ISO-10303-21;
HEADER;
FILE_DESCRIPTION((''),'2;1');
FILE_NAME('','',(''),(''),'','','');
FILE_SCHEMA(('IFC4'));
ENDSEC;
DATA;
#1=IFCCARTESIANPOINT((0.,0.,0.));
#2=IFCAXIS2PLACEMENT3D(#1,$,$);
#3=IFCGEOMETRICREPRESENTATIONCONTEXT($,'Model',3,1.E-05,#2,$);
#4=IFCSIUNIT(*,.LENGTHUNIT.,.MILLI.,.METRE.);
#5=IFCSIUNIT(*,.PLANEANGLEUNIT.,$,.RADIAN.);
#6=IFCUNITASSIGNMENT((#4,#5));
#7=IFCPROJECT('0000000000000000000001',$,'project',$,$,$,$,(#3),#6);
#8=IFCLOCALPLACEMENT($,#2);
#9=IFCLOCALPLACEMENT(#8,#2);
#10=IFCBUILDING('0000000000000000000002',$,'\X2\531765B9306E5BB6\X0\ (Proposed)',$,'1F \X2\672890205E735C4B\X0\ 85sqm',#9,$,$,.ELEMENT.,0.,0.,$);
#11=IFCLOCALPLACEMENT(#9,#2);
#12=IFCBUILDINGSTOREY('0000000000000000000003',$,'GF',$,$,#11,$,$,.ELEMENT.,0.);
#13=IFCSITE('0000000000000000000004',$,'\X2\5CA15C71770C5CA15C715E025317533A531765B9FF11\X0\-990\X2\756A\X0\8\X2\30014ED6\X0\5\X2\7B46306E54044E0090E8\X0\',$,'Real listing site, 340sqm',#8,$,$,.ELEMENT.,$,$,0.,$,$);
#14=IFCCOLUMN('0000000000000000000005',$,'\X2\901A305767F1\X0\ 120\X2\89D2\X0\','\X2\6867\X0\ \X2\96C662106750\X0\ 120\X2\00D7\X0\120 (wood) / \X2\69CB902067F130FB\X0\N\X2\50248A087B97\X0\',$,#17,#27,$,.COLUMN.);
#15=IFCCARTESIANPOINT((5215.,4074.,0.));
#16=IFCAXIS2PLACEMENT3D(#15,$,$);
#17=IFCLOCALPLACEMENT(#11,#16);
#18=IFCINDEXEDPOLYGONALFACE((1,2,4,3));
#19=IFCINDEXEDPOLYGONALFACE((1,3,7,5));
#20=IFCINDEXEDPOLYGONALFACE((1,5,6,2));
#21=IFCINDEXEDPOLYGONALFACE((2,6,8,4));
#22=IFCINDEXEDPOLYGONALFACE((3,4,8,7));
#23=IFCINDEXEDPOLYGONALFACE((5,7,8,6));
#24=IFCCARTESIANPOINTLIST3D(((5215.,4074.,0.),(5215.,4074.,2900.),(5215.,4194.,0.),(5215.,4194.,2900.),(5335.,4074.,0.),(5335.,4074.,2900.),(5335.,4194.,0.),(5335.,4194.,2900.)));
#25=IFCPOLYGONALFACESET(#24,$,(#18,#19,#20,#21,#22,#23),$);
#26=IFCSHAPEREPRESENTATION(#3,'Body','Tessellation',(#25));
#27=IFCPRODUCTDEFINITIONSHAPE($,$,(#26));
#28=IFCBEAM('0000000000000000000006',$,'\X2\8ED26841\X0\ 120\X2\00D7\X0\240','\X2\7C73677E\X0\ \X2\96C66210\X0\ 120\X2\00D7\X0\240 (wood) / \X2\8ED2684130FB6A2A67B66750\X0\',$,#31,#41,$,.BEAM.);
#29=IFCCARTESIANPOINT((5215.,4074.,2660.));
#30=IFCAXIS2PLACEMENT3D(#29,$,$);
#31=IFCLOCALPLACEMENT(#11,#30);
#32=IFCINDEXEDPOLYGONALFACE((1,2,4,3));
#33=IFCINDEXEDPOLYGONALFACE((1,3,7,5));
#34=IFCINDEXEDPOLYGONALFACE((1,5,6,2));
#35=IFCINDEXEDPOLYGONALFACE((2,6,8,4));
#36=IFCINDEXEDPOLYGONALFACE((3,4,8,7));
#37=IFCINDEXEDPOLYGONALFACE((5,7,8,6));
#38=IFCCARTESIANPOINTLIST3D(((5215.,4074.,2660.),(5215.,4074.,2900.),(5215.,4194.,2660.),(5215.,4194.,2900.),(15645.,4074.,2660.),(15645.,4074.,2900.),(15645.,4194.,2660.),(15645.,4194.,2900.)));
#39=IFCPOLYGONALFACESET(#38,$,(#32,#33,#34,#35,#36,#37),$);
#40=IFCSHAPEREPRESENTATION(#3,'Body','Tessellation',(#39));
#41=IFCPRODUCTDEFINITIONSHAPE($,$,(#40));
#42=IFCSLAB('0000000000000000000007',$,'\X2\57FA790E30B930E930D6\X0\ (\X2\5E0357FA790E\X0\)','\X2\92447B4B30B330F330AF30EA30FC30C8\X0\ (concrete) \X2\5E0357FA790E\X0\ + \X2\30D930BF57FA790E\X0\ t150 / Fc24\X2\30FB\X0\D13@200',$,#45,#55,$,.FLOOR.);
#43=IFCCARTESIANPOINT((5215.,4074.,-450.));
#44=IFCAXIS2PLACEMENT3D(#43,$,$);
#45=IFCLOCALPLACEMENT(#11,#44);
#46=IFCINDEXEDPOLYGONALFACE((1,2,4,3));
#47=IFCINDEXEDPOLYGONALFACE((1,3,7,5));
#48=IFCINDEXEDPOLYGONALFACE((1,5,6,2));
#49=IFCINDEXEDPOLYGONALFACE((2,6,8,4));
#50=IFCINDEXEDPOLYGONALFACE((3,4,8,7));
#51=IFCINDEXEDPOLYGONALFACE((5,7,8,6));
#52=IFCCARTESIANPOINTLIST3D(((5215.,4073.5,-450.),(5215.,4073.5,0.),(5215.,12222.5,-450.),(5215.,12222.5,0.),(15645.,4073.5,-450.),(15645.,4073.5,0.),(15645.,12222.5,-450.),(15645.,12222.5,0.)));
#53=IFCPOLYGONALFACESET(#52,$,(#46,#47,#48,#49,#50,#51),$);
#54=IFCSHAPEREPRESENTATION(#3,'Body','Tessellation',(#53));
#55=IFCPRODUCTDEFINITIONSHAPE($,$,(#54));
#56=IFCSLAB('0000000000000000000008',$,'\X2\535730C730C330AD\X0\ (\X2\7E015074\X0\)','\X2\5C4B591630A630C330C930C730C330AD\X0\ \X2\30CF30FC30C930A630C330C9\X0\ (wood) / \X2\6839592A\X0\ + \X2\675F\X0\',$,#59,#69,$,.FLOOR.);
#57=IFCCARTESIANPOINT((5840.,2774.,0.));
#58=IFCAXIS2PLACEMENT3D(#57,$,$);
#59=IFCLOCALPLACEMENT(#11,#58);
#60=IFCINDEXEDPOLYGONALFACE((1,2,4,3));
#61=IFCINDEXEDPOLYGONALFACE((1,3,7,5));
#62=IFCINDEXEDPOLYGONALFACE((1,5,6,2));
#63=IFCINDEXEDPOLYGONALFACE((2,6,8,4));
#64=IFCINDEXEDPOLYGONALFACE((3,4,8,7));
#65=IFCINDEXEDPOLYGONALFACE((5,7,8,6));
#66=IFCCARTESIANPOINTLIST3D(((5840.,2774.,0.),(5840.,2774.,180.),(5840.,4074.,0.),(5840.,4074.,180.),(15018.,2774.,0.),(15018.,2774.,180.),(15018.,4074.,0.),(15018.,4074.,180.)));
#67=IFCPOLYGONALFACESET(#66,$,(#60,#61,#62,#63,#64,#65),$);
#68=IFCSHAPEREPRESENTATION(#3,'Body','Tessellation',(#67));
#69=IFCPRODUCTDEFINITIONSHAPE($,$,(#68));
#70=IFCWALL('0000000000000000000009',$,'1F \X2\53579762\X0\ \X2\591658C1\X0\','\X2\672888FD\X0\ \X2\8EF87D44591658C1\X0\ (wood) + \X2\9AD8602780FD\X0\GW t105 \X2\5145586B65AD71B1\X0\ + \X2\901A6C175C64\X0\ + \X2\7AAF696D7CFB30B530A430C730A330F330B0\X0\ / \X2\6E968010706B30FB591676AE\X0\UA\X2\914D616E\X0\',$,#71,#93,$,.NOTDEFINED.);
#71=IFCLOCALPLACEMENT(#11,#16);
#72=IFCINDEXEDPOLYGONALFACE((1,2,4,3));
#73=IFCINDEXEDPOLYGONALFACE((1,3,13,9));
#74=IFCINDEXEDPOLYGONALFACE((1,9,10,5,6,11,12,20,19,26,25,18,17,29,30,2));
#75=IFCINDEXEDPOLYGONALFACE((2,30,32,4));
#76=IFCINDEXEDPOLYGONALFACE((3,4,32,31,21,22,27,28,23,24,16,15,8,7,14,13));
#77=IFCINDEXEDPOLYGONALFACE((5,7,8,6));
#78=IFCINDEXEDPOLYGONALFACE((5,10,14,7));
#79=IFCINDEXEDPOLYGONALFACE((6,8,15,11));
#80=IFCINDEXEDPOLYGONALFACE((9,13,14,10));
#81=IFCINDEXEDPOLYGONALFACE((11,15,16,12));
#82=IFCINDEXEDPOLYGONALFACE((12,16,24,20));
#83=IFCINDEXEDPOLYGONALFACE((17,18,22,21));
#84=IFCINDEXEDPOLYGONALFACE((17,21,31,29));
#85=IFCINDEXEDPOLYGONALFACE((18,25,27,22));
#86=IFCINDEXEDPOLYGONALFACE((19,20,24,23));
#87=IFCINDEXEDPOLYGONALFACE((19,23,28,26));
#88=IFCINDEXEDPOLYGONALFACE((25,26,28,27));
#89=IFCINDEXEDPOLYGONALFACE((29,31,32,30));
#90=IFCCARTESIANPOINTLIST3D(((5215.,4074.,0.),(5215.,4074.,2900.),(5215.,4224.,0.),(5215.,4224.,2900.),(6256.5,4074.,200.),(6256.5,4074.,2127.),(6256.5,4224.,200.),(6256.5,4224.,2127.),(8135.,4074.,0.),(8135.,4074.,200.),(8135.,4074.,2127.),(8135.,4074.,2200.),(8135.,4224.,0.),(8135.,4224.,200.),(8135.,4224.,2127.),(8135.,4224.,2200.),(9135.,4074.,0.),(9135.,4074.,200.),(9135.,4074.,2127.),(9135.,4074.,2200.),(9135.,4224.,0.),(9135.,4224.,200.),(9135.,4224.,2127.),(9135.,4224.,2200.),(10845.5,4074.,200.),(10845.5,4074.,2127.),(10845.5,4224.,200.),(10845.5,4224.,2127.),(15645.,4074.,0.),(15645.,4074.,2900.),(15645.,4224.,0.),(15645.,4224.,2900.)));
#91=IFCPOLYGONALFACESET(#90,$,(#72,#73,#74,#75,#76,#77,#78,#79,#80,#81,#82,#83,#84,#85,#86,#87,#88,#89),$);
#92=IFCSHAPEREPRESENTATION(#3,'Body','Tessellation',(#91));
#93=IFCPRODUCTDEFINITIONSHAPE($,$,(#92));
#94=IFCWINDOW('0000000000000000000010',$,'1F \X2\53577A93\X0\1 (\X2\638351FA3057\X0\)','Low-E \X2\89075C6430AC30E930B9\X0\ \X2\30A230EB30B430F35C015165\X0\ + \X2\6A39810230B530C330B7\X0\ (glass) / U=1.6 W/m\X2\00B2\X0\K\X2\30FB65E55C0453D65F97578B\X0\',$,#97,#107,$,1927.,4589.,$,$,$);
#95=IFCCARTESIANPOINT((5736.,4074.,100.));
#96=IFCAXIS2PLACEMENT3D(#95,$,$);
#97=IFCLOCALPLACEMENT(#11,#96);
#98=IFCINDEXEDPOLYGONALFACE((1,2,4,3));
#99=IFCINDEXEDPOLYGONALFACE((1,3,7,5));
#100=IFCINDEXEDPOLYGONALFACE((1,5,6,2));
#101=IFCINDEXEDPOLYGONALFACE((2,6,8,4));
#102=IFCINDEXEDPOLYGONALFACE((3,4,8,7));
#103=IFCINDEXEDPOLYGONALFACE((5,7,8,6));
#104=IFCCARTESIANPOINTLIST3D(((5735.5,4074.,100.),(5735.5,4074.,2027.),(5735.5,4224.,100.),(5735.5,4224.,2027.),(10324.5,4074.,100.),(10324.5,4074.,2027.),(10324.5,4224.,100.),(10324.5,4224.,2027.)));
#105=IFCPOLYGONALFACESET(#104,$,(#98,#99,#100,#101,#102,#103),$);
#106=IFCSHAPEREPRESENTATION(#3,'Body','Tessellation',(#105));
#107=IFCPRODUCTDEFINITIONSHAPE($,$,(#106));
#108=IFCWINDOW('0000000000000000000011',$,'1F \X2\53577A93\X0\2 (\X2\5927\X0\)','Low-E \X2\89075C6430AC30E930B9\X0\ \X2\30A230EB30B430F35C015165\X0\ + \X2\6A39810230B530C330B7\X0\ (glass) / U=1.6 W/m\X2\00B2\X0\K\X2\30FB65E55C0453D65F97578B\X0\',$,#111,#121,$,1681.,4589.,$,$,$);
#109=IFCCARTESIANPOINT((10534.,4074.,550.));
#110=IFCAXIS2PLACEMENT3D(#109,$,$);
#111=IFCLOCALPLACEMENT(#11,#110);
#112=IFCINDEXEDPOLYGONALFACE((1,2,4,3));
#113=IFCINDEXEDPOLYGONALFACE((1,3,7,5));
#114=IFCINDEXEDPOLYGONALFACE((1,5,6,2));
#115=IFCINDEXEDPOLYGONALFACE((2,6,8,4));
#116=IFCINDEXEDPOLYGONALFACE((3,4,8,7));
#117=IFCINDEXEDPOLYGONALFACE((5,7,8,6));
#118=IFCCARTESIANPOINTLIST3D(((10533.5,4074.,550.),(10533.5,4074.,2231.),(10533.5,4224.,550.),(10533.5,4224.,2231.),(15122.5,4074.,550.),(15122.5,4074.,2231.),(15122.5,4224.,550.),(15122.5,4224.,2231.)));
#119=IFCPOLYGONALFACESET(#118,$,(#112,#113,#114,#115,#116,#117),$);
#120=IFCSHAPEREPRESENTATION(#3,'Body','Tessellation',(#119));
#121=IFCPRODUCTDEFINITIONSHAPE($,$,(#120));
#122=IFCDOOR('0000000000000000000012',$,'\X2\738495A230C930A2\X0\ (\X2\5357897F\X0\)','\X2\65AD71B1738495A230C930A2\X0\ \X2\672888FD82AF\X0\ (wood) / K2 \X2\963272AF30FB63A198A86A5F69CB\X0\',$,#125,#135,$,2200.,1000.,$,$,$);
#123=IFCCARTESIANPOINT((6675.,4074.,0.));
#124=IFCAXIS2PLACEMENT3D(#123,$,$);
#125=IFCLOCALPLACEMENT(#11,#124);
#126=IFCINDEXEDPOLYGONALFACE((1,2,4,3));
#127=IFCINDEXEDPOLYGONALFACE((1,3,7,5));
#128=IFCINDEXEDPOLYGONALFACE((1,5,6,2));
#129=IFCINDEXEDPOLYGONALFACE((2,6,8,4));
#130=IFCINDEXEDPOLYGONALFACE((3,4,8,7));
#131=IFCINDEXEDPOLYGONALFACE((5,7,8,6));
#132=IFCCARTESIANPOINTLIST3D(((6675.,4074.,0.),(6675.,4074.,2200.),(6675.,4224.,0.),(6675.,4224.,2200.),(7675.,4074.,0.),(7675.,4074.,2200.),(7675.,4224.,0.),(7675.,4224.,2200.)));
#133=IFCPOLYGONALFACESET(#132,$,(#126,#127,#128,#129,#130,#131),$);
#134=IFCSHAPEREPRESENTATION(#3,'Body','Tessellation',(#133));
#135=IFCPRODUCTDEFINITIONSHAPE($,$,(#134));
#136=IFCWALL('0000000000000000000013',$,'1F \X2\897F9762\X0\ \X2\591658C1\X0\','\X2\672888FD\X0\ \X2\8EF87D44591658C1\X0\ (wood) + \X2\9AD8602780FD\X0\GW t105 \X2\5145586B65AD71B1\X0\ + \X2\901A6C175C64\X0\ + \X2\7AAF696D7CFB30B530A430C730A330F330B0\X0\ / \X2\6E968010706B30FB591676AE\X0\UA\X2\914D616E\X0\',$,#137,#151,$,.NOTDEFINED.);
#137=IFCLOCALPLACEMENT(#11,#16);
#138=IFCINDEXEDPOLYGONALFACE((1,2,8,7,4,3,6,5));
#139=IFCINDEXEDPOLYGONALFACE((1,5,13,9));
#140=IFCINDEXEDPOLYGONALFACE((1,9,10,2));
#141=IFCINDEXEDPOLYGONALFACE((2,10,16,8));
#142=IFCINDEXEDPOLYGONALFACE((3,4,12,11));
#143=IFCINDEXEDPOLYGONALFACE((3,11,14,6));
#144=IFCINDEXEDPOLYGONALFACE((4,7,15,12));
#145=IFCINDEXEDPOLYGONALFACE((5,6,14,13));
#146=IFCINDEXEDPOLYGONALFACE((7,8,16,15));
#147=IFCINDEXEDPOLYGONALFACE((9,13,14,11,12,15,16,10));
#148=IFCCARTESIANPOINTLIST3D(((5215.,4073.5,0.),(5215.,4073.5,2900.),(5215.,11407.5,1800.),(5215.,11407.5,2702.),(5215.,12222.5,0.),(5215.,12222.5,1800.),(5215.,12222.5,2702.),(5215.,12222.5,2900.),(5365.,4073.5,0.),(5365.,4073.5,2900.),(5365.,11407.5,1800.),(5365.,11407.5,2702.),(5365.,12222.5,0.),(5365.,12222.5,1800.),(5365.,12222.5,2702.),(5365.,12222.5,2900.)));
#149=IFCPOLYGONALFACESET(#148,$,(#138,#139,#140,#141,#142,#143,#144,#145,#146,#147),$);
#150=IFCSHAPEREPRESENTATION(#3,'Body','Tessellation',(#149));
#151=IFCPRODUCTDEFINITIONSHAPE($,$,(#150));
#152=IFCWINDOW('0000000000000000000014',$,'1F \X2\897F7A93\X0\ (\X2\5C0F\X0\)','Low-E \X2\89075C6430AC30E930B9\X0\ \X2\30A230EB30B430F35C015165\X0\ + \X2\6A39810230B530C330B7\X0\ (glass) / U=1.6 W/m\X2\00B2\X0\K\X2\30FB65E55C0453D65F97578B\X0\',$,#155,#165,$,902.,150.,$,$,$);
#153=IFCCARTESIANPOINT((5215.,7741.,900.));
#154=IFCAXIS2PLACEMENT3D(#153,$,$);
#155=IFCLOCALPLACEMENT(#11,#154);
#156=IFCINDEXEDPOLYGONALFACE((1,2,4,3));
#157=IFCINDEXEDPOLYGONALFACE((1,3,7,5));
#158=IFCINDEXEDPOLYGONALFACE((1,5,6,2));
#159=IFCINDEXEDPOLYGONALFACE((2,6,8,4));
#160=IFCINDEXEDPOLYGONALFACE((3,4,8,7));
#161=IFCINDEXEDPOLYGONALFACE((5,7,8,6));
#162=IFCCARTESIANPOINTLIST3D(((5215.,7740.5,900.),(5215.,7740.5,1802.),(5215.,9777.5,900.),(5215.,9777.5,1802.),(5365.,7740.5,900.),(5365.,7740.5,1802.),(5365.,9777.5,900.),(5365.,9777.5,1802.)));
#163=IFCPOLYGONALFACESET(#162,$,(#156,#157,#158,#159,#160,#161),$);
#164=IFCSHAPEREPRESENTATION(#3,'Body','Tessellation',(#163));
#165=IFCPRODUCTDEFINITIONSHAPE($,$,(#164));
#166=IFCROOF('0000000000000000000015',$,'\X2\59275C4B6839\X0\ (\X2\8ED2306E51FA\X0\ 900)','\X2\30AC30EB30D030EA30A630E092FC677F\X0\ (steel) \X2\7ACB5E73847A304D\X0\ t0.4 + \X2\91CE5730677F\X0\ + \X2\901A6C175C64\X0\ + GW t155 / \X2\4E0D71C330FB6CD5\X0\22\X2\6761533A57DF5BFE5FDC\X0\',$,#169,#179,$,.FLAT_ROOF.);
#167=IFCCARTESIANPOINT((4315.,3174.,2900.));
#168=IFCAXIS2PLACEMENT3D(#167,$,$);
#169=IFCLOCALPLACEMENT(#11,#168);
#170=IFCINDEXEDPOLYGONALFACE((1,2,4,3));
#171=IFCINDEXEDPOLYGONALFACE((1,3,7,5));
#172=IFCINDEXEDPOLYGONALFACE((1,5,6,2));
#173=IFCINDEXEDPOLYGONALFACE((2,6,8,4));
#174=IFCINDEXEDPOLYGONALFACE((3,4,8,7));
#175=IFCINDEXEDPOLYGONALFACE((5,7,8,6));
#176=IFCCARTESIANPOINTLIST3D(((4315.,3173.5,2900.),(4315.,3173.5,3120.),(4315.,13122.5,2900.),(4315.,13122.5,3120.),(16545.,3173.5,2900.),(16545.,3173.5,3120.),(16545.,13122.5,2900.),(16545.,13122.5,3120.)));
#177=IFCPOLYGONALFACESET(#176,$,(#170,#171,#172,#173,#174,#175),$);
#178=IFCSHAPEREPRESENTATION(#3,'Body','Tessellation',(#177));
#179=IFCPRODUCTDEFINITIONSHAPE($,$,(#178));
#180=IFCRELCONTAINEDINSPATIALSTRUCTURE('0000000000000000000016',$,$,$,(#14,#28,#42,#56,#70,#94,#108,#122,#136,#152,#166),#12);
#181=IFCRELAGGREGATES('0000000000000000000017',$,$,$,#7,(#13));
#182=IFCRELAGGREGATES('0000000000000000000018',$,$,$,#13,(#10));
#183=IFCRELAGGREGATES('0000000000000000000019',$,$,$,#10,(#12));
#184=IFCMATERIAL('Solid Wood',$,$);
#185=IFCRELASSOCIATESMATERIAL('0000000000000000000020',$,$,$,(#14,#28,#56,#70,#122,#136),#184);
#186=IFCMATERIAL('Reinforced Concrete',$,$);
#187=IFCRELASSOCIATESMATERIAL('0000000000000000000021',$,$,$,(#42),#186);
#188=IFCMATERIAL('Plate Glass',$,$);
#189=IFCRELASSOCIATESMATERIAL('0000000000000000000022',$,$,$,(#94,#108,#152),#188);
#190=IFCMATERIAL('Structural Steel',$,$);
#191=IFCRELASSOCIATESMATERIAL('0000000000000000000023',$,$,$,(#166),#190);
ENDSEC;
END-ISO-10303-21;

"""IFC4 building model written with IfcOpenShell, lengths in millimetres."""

from ifc_helpers import new_model, si_unit, frame, frame_2d, origin, place, context, project, spatial, rectangle, extrude, material, element, fill, save


model = new_model("IFC4")

# Units and contexts
model_context = context("Model", 3, precision=1e-05, world=origin())
ifc_project = project(units=[si_unit("LENGTHUNIT", "METRE", prefix="MILLI"), si_unit("PLANEANGLEUNIT", "RADIAN")], contexts=[model_context])

# Site, building, storey
site_placement = place(None, origin())
site = spatial("IfcSite", under=ifc_project, at=site_placement, Name="岡山県岡山市北区北方１-990番8、他5筆の各一部", ObjectType="Real listing site, 340sqm", CompositionType="ELEMENT", RefElevation=0.0)
building_placement = place(site_placement, origin())
building = spatial("IfcBuilding", under=site, at=building_placement, Name="北方の家 (Proposed)", ObjectType="1F 木造平屋 85sqm", CompositionType="ELEMENT", ElevationOfRefHeight=0.0, ElevationOfTerrain=0.0)
storey_placement = place(building_placement, origin())
storey = spatial("IfcBuildingStorey", under=building, at=storey_placement, Name="GF", CompositionType="ELEMENT", Elevation=0.0)

# Column
ifc_material_1 = material(Name="Solid Wood")
column_1_placement = place(storey_placement, frame((5215.0, 4074.0, 0.0)))
element("IfcColumn", 1, at=column_1_placement, inside=storey, material=ifc_material_1, Name="通し柱 120角", Description="桧 集成材 120×120 (wood) / 構造柱・N値計算", PredefinedType="COLUMN", context=model_context, shape_type="SweptSolid", body=[
    extrude(rectangle(XDim=120.0, YDim=120.0, at=frame_2d((60.0, 60.0))), frame((5215.0, 4074.0, 0.0)), (0.0, 0.0, 1.0), 2900.0),
])

# Beam
beam_1_placement = place(storey_placement, frame((5215.0, 4074.0, 2660.0)))
element("IfcBeam", 2, at=beam_1_placement, inside=storey, material=ifc_material_1, Name="軒桁 120×240", Description="米松 集成 120×240 (wood) / 軒桁・横架材", PredefinedType="BEAM", context=model_context, shape_type="SweptSolid", body=[
    extrude(rectangle(XDim=10430.0, YDim=120.0, at=frame_2d((5215.0, 60.0))), frame((5215.0, 4074.0, 2660.0)), (0.0, 0.0, 1.0), 240.0),
])

# Slabs
ifc_material_2 = material(Name="Reinforced Concrete")
slab_1_placement = place(storey_placement, frame((5215.0, 4074.0, -450.0)))
element("IfcSlab", 3, at=slab_1_placement, inside=storey, material=ifc_material_2, Name="基礎スラブ (布基礎)", Description="鉄筋コンクリート (concrete) 布基礎 + ベタ基礎 t150 / Fc24・D13@200", PredefinedType="FLOOR", context=model_context, shape_type="SweptSolid", body=[
    extrude(rectangle(XDim=10430.0, YDim=8149.0, at=frame_2d((5215.0, 4074.0))), frame((5215.0, 4074.0, -450.0)), (0.0, 0.0, 1.0), 450.0),
])
slab_2_placement = place(storey_placement, frame((5840.0, 2774.0, 0.0)))
element("IfcSlab", 4, at=slab_2_placement, inside=storey, material=ifc_material_1, Name="南デッキ (縁側)", Description="屋外ウッドデッキ ハードウッド (wood) / 根太 + 束", PredefinedType="FLOOR", context=model_context, shape_type="SweptSolid", body=[
    extrude(rectangle(XDim=9178.0, YDim=1300.0, at=frame_2d((4589.0, 650.0))), frame((5840.0, 2774.0, 0.0)), (0.0, 0.0, 1.0), 180.0),
])

# Wall, openings, windows, door
wall_1_placement = place(storey_placement, frame((5215.0, 4074.0, 0.0)))
wall_1 = element("IfcWall", 5, at=wall_1_placement, inside=storey, material=ifc_material_1, Name="1F 南面 外壁", Description="木製 軸組外壁 (wood) + 高性能GW t105 充填断熱 + 通気層 + 窯業系サイディング / 準耐火・外皮UA配慮", PredefinedType="NOTDEFINED", context=model_context, shape_type="SweptSolid", body=[
    extrude(rectangle(XDim=10430.0, YDim=150.0, at=frame_2d((5215.0, 75.0))), frame((5215.0, 4074.0, 0.0)), (0.0, 0.0, 1.0), 2900.0),
])
opening_1_placement = place(storey_placement, frame((5736.0, 4074.0, 100.0)))
opening_1 = element("IfcOpeningElement", 6, at=opening_1_placement, cuts=wall_1, PredefinedType="NOTDEFINED", context=model_context, shape_type="SweptSolid", body=[
    extrude(rectangle(XDim=4589.0, YDim=150.0, at=frame_2d((2294.0, 75.0))), frame((5736.0, 4074.0, 100.0)), (0.0, 0.0, 1.0), 1927.0),
])
opening_2_placement = place(storey_placement, frame((10534.0, 4074.0, 550.0)))
opening_2 = element("IfcOpeningElement", 7, at=opening_2_placement, cuts=wall_1, PredefinedType="NOTDEFINED", context=model_context, shape_type="SweptSolid", body=[
    extrude(rectangle(XDim=4589.0, YDim=150.0, at=frame_2d((2294.0, 75.0))), frame((10534.0, 4074.0, 550.0)), (0.0, 0.0, 1.0), 1681.0),
])
opening_3_placement = place(storey_placement, frame((6675.0, 4074.0, 0.0)))
opening_3 = element("IfcOpeningElement", 8, at=opening_3_placement, cuts=wall_1, PredefinedType="NOTDEFINED", context=model_context, shape_type="SweptSolid", body=[
    extrude(rectangle(XDim=1000.0, YDim=150.0, at=frame_2d((500.0, 75.0))), frame((6675.0, 4074.0, 0.0)), (0.0, 0.0, 1.0), 2200.0),
])
ifc_material_3 = material(Name="Plate Glass")
window_1_placement = place(storey_placement, frame((5736.0, 4074.0, 100.0)))
window_1 = element("IfcWindow", 9, at=window_1_placement, inside=storey, material=ifc_material_3, Name="1F 南窓1 (掃出し)", Description="Low-E 複層ガラス アルゴン封入 + 樹脂サッシ (glass) / U=1.6 W/m²K・日射取得型", OverallHeight=1927.0, OverallWidth=4589.0, context=model_context, shape_type="SweptSolid", body=[
    extrude(rectangle(XDim=4589.0, YDim=150.0, at=frame_2d((2294.0, 75.0))), frame((5736.0, 4074.0, 100.0)), (0.0, 0.0, 1.0), 1927.0),
])
fill(opening_1, window_1)
window_2_placement = place(storey_placement, frame((10534.0, 4074.0, 550.0)))
window_2 = element("IfcWindow", 10, at=window_2_placement, inside=storey, material=ifc_material_3, Name="1F 南窓2 (大)", Description="Low-E 複層ガラス アルゴン封入 + 樹脂サッシ (glass) / U=1.6 W/m²K・日射取得型", OverallHeight=1681.0, OverallWidth=4589.0, context=model_context, shape_type="SweptSolid", body=[
    extrude(rectangle(XDim=4589.0, YDim=150.0, at=frame_2d((2294.0, 75.0))), frame((10534.0, 4074.0, 550.0)), (0.0, 0.0, 1.0), 1681.0),
])
fill(opening_2, window_2)
door_placement = place(storey_placement, frame((6675.0, 4074.0, 0.0)))
door = element("IfcDoor", 11, at=door_placement, inside=storey, material=ifc_material_1, Name="玄関ドア (南西)", Description="断熱玄関ドア 木製芯 (wood) / K2 防犯・採風機構", OverallHeight=2200.0, OverallWidth=1000.0, context=model_context, shape_type="SweptSolid", body=[
    extrude(rectangle(XDim=1000.0, YDim=150.0, at=frame_2d((500.0, 75.0))), frame((6675.0, 4074.0, 0.0)), (0.0, 0.0, 1.0), 2200.0),
])
fill(opening_3, door)

# Wall, opening, window
wall_2_placement = place(storey_placement, frame((5215.0, 4074.0, 0.0)))
wall_2 = element("IfcWall", 12, at=wall_2_placement, inside=storey, material=ifc_material_1, Name="1F 西面 外壁", Description="木製 軸組外壁 (wood) + 高性能GW t105 充填断熱 + 通気層 + 窯業系サイディング / 準耐火・外皮UA配慮", PredefinedType="NOTDEFINED", context=model_context, shape_type="SweptSolid", body=[
    extrude(rectangle(XDim=150.0, YDim=8149.0, at=frame_2d((75.0, 4074.0))), frame((5215.0, 4074.0, 0.0)), (0.0, 0.0, 1.0), 2900.0),
])
opening_4_placement = place(storey_placement, frame((5215.0, 7741.0, 900.0)))
opening_4 = element("IfcOpeningElement", 13, at=opening_4_placement, cuts=wall_2, PredefinedType="NOTDEFINED", context=model_context, shape_type="SweptSolid", body=[
    extrude(rectangle(XDim=150.0, YDim=2037.0, at=frame_2d((75.0, 1018.0))), frame((5215.0, 7741.0, 900.0)), (0.0, 0.0, 1.0), 902.0),
])
window_3_placement = place(storey_placement, frame((5215.0, 7741.0, 900.0)))
window_3 = element("IfcWindow", 14, at=window_3_placement, inside=storey, material=ifc_material_3, Name="1F 西窓 (小)", Description="Low-E 複層ガラス アルゴン封入 + 樹脂サッシ (glass) / U=1.6 W/m²K・日射取得型", OverallHeight=902.0, OverallWidth=150.0, context=model_context, shape_type="SweptSolid", body=[
    extrude(rectangle(XDim=150.0, YDim=2037.0, at=frame_2d((75.0, 1018.0))), frame((5215.0, 7741.0, 900.0)), (0.0, 0.0, 1.0), 902.0),
])
fill(opening_4, window_3)

# Roof
ifc_material_4 = material(Name="Structural Steel")
roof_placement = place(storey_placement, frame((4315.0, 3174.0, 2900.0)))
element("IfcRoof", 15, at=roof_placement, inside=storey, material=ifc_material_4, Name="大屋根 (軒の出 900)", Description="ガルバリウム鋼板 (steel) 立平葺き t0.4 + 野地板 + 通気層 + GW t155 / 不燃・法22条区域対応", PredefinedType="FLAT_ROOF", context=model_context, shape_type="SweptSolid", body=[
    extrude(rectangle(XDim=12230.0, YDim=9949.0, at=frame_2d((6115.0, 4974.0))), frame((4315.0, 3174.0, 2900.0)), (0.0, 0.0, 1.0), 220.0),
])

save(model, "model.ifc")
